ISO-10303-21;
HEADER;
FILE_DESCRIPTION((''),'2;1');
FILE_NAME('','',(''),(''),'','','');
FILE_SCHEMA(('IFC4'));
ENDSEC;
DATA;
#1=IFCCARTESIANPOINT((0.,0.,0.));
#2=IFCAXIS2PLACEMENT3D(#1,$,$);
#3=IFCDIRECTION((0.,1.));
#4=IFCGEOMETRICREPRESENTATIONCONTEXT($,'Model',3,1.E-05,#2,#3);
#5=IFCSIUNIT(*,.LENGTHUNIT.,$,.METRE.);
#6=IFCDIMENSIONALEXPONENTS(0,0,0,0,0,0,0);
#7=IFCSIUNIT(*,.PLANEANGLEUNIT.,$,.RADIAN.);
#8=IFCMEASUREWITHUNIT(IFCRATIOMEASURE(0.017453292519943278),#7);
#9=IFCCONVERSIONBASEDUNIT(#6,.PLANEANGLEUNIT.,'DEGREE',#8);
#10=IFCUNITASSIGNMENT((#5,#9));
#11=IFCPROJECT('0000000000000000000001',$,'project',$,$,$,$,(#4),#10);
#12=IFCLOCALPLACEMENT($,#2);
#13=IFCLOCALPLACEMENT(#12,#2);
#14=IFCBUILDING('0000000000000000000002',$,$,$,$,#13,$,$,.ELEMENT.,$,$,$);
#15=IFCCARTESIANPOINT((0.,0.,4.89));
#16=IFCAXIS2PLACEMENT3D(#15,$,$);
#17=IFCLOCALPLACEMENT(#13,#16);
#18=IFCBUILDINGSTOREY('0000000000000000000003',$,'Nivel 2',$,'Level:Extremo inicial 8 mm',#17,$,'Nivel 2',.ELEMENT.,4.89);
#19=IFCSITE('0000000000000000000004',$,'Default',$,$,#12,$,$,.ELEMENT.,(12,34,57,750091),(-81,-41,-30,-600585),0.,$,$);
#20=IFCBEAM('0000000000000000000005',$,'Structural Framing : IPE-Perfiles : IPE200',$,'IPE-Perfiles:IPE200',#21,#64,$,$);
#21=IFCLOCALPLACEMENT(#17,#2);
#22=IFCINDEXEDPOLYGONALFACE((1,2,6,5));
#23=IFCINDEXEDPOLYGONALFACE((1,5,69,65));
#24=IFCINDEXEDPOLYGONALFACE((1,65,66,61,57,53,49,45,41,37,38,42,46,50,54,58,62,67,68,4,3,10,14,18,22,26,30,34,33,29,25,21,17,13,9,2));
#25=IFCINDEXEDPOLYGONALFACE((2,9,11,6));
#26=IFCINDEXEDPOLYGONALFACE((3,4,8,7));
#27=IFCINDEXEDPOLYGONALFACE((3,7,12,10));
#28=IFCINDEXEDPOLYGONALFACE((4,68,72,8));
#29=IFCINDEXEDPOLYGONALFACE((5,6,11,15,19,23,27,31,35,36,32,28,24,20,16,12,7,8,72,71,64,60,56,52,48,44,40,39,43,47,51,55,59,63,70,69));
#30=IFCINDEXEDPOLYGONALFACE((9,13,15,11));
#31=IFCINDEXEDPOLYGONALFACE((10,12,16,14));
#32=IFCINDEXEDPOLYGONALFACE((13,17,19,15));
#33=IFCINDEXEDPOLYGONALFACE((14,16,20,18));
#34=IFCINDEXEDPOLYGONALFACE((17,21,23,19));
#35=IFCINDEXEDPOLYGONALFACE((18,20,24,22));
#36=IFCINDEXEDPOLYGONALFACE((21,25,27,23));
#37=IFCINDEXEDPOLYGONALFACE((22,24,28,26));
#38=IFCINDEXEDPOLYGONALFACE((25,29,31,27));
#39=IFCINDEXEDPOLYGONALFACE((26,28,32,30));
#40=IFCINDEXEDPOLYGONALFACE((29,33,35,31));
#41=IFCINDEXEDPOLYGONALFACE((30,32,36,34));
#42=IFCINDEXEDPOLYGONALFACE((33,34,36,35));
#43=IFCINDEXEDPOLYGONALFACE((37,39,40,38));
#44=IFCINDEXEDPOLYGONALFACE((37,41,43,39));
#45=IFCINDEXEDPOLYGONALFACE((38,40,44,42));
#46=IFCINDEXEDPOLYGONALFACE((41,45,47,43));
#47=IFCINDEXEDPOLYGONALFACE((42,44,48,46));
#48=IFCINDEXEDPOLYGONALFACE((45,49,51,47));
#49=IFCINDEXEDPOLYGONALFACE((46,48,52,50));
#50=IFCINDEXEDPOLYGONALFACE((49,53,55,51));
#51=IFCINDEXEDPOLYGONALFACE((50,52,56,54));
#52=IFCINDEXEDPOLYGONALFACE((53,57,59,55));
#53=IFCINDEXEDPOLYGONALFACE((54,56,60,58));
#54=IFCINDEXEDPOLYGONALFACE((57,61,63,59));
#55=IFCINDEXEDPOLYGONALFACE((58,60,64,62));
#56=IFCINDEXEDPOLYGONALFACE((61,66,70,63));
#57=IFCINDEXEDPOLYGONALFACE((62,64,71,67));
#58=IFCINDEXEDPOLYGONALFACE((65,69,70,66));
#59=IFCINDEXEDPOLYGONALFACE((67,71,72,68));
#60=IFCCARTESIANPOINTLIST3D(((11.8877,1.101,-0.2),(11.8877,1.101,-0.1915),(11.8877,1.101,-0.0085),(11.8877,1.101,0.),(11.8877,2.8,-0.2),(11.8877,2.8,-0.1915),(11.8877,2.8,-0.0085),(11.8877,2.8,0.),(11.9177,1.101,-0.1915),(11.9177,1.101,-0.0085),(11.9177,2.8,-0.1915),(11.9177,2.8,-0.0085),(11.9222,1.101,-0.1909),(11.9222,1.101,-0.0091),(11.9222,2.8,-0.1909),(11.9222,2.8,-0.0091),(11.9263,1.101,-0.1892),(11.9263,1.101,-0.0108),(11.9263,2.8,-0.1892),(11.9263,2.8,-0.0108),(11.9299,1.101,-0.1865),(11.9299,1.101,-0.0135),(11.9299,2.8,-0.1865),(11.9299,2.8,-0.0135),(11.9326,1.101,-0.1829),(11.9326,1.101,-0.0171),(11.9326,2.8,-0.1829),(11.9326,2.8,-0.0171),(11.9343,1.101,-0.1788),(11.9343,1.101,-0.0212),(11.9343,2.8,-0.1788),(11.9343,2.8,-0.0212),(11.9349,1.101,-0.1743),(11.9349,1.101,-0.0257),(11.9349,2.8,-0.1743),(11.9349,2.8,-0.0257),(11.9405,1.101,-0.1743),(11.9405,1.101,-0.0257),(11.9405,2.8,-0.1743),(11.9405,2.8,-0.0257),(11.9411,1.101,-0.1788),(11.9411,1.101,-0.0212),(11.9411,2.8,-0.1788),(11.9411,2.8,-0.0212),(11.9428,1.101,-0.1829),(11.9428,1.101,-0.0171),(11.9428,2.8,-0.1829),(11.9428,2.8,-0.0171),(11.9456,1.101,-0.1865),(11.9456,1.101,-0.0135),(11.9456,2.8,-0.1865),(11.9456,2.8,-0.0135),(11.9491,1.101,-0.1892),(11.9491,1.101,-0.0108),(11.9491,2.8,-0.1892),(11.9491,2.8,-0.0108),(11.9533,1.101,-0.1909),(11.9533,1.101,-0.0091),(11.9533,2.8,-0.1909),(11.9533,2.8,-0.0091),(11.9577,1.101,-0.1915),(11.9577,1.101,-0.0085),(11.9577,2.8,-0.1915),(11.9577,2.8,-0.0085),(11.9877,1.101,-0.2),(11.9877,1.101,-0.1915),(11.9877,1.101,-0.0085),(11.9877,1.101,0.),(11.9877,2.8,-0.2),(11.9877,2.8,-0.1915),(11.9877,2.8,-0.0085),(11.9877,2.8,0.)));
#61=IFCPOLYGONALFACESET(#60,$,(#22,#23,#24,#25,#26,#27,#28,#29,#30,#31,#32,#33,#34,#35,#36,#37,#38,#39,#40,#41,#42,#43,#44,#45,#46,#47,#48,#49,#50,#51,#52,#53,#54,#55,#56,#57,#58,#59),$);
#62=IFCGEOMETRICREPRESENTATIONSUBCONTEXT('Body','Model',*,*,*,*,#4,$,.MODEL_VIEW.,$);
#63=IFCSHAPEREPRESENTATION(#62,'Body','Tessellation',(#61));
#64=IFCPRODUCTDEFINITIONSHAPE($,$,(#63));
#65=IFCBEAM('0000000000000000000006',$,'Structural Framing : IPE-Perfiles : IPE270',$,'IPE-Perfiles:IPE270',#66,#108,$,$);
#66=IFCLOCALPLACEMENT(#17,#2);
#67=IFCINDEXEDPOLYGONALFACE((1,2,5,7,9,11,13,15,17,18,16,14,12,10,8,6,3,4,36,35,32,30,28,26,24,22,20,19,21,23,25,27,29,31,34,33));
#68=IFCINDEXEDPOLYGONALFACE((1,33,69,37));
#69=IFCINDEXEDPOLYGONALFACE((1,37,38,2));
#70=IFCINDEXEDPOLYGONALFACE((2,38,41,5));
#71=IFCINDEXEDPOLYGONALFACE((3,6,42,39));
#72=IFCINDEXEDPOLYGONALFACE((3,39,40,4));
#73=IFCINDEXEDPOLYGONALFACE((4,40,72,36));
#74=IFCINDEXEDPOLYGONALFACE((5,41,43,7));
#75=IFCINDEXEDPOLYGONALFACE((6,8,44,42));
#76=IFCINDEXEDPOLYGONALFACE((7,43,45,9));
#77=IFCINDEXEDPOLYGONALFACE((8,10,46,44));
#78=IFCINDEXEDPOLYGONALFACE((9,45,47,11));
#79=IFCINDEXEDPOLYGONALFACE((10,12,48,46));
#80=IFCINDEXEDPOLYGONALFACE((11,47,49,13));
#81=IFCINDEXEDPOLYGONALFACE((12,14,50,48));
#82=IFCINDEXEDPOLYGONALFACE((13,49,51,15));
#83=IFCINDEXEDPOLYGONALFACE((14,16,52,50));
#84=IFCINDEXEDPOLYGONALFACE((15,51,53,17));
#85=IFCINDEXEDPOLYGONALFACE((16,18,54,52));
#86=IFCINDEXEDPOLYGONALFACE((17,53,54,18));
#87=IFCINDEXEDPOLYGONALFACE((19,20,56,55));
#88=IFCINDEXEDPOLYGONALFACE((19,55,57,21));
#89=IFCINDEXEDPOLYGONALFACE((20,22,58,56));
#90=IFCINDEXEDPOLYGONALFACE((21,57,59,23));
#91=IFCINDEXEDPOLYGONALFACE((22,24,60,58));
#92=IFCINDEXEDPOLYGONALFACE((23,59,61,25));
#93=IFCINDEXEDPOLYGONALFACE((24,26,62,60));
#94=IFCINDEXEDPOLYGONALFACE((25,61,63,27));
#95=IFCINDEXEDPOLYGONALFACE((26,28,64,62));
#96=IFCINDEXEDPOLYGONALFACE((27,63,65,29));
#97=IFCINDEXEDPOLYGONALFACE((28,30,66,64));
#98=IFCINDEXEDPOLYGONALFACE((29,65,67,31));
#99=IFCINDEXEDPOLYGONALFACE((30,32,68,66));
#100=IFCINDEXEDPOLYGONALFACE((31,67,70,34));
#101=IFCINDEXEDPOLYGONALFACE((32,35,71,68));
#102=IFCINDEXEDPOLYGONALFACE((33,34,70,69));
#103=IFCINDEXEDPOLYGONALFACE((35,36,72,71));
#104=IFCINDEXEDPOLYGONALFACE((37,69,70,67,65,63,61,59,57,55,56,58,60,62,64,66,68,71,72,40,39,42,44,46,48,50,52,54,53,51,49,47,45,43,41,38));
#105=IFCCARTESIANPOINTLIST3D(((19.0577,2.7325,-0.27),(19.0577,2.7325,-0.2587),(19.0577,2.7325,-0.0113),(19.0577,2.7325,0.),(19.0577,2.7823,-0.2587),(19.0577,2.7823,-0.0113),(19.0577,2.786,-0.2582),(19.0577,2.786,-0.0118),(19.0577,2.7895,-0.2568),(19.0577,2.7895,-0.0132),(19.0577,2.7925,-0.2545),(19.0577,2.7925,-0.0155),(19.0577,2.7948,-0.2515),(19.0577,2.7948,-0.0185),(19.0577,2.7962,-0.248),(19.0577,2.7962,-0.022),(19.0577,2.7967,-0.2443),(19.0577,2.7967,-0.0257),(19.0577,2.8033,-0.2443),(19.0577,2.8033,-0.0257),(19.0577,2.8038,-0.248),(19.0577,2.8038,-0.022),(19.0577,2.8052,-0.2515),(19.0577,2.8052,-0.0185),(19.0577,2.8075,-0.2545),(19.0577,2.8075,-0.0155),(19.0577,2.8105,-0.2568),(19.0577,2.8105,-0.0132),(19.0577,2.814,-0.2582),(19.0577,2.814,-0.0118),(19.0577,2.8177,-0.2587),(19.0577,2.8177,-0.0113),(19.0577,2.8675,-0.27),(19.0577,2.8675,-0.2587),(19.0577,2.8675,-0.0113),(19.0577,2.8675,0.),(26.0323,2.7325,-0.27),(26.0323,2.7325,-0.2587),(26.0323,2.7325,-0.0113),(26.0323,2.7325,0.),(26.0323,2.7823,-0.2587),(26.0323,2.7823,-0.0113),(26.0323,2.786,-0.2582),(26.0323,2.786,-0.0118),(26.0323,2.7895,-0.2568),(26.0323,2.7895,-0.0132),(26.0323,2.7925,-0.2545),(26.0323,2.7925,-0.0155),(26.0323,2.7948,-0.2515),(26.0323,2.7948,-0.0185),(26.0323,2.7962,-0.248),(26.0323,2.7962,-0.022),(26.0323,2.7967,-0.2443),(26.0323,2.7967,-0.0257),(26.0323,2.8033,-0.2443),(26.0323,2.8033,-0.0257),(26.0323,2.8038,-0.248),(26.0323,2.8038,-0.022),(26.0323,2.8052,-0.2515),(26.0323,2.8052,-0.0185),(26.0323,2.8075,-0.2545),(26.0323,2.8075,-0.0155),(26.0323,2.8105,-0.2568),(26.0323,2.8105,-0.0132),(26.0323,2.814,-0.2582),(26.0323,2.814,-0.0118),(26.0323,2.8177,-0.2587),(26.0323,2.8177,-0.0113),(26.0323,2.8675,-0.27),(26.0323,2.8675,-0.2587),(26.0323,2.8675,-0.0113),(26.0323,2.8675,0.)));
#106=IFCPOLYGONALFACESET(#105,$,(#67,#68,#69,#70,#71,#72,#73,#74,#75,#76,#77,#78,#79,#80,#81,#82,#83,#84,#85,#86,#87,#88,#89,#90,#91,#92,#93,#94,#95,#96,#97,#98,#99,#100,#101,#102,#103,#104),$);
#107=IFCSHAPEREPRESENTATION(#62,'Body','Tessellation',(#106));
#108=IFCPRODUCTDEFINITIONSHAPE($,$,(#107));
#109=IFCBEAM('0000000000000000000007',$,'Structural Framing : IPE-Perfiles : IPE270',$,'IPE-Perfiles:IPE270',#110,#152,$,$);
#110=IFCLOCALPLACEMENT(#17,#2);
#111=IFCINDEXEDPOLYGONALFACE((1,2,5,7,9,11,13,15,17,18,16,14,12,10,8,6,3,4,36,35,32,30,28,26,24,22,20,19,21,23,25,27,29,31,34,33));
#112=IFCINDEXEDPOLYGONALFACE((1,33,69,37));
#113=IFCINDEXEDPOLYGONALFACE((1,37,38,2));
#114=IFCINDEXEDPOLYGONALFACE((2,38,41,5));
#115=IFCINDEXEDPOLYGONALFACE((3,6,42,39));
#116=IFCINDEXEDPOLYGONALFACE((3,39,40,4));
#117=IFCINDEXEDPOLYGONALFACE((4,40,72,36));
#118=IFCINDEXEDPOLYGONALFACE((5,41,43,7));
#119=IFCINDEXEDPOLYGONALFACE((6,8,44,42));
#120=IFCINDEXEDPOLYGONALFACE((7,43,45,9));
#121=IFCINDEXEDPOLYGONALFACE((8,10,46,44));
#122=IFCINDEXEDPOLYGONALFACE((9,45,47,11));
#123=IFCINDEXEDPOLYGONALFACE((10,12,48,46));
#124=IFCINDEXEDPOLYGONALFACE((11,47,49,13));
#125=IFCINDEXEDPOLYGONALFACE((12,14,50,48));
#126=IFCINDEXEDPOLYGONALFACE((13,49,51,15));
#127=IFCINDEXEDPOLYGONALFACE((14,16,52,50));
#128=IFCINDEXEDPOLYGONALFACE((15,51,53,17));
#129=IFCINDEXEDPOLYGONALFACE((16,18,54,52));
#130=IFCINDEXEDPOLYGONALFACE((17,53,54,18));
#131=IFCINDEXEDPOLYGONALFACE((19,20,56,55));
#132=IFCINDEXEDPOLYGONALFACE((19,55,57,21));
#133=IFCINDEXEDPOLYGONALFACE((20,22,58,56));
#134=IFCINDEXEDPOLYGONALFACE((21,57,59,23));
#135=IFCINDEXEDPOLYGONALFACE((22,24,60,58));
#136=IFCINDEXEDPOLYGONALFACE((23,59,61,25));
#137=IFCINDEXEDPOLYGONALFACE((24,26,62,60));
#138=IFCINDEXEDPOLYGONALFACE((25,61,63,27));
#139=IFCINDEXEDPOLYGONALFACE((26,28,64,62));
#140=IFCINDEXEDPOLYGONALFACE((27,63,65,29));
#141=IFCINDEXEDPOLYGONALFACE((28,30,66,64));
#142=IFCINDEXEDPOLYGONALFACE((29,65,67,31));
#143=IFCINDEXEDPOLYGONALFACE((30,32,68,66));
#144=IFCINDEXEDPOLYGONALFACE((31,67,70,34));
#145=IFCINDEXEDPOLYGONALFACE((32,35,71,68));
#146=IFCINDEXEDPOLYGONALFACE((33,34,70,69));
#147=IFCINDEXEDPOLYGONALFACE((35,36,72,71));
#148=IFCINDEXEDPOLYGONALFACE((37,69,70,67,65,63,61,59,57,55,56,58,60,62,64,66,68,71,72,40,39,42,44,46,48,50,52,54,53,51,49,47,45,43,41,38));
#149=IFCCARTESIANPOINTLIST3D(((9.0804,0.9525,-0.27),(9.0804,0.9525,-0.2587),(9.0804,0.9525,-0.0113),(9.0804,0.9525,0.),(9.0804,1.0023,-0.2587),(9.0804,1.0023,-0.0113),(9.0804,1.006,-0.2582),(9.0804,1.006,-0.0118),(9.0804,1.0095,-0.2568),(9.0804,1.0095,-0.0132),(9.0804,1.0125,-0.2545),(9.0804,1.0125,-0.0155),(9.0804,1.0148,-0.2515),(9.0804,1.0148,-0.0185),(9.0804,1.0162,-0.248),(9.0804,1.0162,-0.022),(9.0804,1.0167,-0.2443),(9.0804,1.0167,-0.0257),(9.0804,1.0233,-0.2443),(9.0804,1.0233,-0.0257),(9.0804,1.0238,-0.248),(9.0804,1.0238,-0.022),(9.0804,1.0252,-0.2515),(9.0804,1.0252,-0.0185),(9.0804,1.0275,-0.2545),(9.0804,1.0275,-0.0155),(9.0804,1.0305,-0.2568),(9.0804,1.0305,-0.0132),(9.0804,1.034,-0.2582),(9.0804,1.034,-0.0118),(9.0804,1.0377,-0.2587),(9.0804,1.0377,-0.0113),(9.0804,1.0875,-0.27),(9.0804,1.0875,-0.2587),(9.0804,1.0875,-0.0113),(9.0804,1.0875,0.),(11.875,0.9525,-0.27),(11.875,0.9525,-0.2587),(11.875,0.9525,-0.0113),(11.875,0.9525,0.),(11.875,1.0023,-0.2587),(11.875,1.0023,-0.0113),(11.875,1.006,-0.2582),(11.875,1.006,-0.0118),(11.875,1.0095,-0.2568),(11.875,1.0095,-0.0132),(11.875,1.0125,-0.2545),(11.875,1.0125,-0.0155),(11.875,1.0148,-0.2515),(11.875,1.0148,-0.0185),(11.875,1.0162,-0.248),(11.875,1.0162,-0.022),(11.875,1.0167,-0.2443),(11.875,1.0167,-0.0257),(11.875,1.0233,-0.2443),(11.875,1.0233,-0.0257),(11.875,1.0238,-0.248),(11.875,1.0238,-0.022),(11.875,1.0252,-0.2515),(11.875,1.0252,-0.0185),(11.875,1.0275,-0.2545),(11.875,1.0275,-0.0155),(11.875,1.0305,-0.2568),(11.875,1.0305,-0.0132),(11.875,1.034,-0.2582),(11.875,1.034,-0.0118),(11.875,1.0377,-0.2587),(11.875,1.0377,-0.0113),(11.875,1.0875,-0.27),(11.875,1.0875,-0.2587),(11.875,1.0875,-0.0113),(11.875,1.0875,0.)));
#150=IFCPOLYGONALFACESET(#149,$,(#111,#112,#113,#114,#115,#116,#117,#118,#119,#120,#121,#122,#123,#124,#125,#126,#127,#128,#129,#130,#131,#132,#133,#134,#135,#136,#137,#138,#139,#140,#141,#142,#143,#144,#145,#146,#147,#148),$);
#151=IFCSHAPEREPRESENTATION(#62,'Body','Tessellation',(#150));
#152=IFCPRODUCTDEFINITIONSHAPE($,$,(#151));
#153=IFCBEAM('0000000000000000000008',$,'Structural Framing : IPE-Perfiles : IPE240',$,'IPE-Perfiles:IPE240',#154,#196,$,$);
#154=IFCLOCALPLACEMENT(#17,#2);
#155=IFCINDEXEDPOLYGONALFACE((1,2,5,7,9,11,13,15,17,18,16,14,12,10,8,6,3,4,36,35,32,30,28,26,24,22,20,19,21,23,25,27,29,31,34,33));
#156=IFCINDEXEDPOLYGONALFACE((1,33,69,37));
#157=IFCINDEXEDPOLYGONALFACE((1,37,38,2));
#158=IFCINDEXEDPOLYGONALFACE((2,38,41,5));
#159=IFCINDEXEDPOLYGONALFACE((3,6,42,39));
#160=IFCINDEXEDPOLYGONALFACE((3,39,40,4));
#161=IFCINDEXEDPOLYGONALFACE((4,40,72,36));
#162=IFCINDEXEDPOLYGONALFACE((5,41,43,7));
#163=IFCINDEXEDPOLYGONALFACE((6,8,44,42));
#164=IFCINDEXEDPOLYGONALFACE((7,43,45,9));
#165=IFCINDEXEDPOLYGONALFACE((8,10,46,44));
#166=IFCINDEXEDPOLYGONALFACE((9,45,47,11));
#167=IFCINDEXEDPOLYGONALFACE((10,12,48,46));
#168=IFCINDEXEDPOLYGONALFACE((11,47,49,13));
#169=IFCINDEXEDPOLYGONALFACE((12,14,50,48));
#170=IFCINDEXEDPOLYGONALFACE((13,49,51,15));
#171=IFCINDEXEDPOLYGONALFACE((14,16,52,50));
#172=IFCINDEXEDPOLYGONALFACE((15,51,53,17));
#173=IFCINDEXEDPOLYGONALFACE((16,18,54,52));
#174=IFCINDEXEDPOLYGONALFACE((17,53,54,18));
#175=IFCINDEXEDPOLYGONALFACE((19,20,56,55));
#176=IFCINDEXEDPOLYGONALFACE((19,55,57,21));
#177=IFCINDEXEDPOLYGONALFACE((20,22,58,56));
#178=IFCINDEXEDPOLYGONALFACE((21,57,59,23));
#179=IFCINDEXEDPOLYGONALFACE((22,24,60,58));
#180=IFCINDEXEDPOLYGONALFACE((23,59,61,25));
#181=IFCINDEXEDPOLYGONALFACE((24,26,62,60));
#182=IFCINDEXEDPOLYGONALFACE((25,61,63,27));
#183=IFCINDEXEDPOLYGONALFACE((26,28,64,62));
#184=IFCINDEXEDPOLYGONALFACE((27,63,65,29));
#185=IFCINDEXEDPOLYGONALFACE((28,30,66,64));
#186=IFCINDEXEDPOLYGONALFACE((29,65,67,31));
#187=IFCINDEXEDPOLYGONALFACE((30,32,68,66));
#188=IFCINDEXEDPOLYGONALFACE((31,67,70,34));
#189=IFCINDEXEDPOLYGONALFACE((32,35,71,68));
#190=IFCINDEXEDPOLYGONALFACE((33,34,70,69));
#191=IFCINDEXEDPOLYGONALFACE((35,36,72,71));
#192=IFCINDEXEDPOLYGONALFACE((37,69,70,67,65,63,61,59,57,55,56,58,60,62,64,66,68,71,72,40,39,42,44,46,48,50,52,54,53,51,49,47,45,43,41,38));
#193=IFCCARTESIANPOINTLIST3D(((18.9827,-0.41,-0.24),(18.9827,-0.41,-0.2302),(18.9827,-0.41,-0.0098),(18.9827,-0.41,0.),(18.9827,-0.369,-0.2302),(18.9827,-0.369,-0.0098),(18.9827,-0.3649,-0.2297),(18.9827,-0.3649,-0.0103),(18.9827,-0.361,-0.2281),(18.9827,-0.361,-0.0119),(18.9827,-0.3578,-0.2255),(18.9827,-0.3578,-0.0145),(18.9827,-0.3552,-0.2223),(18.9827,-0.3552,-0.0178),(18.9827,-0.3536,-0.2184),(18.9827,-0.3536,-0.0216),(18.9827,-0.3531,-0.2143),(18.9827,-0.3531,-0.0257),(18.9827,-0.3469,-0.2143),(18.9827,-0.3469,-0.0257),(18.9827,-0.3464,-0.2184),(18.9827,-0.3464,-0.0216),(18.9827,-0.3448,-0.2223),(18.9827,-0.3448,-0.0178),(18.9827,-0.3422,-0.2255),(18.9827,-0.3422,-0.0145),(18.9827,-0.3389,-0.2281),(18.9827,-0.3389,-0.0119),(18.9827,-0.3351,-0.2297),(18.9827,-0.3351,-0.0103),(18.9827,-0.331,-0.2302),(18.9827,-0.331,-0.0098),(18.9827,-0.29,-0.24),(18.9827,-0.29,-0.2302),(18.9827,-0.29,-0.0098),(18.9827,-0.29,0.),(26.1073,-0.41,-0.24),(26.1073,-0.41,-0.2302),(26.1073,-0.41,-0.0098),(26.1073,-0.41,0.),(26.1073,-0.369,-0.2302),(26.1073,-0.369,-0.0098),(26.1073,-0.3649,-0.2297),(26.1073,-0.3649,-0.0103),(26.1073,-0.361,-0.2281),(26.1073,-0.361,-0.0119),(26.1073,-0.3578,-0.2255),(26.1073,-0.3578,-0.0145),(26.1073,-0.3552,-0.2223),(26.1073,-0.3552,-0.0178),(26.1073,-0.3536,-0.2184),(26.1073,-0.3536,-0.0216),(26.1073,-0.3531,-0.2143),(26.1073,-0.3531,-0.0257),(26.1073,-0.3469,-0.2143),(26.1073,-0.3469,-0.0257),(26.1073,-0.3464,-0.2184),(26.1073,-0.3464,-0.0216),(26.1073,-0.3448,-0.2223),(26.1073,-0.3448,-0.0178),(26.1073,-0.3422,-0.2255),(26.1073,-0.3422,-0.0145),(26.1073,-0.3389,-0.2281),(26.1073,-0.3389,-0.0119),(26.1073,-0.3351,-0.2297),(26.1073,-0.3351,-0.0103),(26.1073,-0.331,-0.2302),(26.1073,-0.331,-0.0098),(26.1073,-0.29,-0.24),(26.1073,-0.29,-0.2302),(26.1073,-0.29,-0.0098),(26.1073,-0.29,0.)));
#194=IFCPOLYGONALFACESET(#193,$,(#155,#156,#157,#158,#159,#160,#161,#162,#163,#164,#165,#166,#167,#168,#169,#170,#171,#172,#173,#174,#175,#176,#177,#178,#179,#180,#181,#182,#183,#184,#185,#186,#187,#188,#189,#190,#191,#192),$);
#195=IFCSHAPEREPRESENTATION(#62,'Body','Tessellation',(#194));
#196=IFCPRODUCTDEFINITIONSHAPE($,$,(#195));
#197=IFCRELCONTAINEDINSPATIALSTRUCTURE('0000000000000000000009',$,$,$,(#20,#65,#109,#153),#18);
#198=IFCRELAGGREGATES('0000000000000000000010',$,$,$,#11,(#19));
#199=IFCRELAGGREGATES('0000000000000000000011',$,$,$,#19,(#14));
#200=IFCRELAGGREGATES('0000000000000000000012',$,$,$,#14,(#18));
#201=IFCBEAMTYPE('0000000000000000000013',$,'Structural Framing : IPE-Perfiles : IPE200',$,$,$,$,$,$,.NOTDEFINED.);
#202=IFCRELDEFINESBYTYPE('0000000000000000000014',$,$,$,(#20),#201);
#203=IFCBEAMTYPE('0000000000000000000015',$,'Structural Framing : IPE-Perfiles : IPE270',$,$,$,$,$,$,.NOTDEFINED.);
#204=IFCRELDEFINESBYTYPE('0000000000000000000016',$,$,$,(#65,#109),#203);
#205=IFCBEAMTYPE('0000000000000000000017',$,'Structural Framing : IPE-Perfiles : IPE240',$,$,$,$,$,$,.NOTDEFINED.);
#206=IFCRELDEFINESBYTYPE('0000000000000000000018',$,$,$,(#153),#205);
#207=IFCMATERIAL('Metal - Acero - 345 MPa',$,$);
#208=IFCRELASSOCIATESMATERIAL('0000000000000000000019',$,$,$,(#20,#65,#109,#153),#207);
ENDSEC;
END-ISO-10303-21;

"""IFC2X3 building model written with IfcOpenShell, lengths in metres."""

from ifc_helpers import new_model, entity, si_unit, converted_unit, direction, frame, frame_2d, origin, place, context, subcontext, project, spatial, i_section, extrude, material, type_object, element, save


model = new_model("IFC2X3")

# Units and contexts
model_context = context("Model", 3, precision=1e-05, world=origin(), true_north=direction((0.0, 1.0)))
body_context = subcontext(model_context, "Body", "Model", "MODEL_VIEW")
ifc_project = project(units=[si_unit("LENGTHUNIT", "METRE"), converted_unit("PLANEANGLEUNIT", "DEGREE", entity("IfcRatioMeasure", 0.017453292519943278), si_unit("PLANEANGLEUNIT", "RADIAN"), dimensions=[0, 0, 0, 0, 0, 0, 0])], contexts=[model_context])

# Site, building, storey
site_placement = place(None, origin())
site = spatial("IfcSite", under=ifc_project, at=site_placement, Name="Default", CompositionType="ELEMENT", RefLatitude=(12, 34, 57, 750091), RefLongitude=(-81, -41, -30, -600585), RefElevation=0.0)
building_placement = place(site_placement, origin())
building = spatial("IfcBuilding", under=site, at=building_placement, CompositionType="ELEMENT")
storey_placement = place(building_placement, frame((0.0, 0.0, 4.89)))
storey = spatial("IfcBuildingStorey", under=building, at=storey_placement, Name="Nivel 2", ObjectType="Level:Extremo inicial 8 mm", LongName="Nivel 2", CompositionType="ELEMENT", Elevation=4.89)

# Shared definitions
ifc_material_1 = material(Name="Metal - Acero - 345 MPa")

# Beams
beam_type_1 = type_object("IfcBeamType", Name="Structural Framing : IPE-Perfiles : IPE200", PredefinedType="NOTDEFINED")
beam_1_placement = place(storey_placement, frame((11.9377, 1.02, 0.0), z_axis=(0.0, 0.0, 1.0), x_axis=(0.0, 1.0, 0.0)))
element("IfcBeam", 1, at=beam_1_placement, inside=storey, type_object=beam_type_1, material=ifc_material_1, Name="Structural Framing : IPE-Perfiles : IPE200", ObjectType="IPE-Perfiles:IPE200", context=body_context, shape_type="SweptSolid", body=[
    extrude(i_section(OverallWidth=0.1, OverallDepth=0.2, WebThickness=0.0056, FlangeThickness=0.0085, FilletRadius=0.0172, at=frame_2d((0.0, 0.0), x_axis=(0.0, 1.0))), frame((0.081, 0.0, -0.1), z_axis=(1.0, 0.0, 0.0), x_axis=(0.0, 0.0, -1.0)), (0.0, 0.0, 1.0), 1.699),
])
beam_type_2 = type_object("IfcBeamType", Name="Structural Framing : IPE-Perfiles : IPE270", PredefinedType="NOTDEFINED")
beam_2_placement = place(storey_placement, frame((18.895, 2.8, 0.0)))
element("IfcBeam", 2, at=beam_2_placement, inside=storey, type_object=beam_type_2, material=ifc_material_1, Name="Structural Framing : IPE-Perfiles : IPE270", ObjectType="IPE-Perfiles:IPE270", context=body_context, shape_type="SweptSolid", body=[
    extrude(i_section(OverallWidth=0.135, OverallDepth=0.27, WebThickness=0.0066, FlangeThickness=0.0113, FilletRadius=0.0144, at=frame_2d((0.0, 0.0), x_axis=(0.0, 1.0))), frame((0.1627, 0.0, -0.135), z_axis=(1.0, 0.0, 0.0), x_axis=(0.0, 0.0, -1.0)), (0.0, 0.0, 1.0), 6.9746),
])
beam_3_placement = place(storey_placement, frame((8.9827, 1.02, 0.0)))
element("IfcBeam", 3, at=beam_3_placement, inside=storey, type_object=beam_type_2, material=ifc_material_1, Name="Structural Framing : IPE-Perfiles : IPE270", ObjectType="IPE-Perfiles:IPE270", context=body_context, shape_type="SweptSolid", body=[
    extrude(i_section(OverallWidth=0.135, OverallDepth=0.27, WebThickness=0.0066, FlangeThickness=0.0113, FilletRadius=0.0144, at=frame_2d((0.0, 0.0), x_axis=(0.0, 1.0))), frame((0.0977, 0.0, -0.135), z_axis=(1.0, 0.0, 0.0), x_axis=(0.0, 0.0, -1.0)), (0.0, 0.0, 1.0), 2.7946),
])
beam_type_3 = type_object("IfcBeamType", Name="Structural Framing : IPE-Perfiles : IPE240", PredefinedType="NOTDEFINED")
beam_4_placement = place(storey_placement, frame((18.895, -0.35, 0.0)))
element("IfcBeam", 4, at=beam_4_placement, inside=storey, type_object=beam_type_3, material=ifc_material_1, Name="Structural Framing : IPE-Perfiles : IPE240", ObjectType="IPE-Perfiles:IPE240", context=body_context, shape_type="SweptSolid", body=[
    extrude(i_section(OverallWidth=0.12, OverallDepth=0.24, WebThickness=0.0062, FlangeThickness=0.0098, FilletRadius=0.0159, at=frame_2d((0.0, 0.0), x_axis=(0.0, 1.0))), frame((0.0877, 0.0, -0.12), z_axis=(1.0, 0.0, 0.0), x_axis=(0.0, 0.0, -1.0)), (0.0, 0.0, 1.0), 7.1246),
])

save(model, "model.ifc")
